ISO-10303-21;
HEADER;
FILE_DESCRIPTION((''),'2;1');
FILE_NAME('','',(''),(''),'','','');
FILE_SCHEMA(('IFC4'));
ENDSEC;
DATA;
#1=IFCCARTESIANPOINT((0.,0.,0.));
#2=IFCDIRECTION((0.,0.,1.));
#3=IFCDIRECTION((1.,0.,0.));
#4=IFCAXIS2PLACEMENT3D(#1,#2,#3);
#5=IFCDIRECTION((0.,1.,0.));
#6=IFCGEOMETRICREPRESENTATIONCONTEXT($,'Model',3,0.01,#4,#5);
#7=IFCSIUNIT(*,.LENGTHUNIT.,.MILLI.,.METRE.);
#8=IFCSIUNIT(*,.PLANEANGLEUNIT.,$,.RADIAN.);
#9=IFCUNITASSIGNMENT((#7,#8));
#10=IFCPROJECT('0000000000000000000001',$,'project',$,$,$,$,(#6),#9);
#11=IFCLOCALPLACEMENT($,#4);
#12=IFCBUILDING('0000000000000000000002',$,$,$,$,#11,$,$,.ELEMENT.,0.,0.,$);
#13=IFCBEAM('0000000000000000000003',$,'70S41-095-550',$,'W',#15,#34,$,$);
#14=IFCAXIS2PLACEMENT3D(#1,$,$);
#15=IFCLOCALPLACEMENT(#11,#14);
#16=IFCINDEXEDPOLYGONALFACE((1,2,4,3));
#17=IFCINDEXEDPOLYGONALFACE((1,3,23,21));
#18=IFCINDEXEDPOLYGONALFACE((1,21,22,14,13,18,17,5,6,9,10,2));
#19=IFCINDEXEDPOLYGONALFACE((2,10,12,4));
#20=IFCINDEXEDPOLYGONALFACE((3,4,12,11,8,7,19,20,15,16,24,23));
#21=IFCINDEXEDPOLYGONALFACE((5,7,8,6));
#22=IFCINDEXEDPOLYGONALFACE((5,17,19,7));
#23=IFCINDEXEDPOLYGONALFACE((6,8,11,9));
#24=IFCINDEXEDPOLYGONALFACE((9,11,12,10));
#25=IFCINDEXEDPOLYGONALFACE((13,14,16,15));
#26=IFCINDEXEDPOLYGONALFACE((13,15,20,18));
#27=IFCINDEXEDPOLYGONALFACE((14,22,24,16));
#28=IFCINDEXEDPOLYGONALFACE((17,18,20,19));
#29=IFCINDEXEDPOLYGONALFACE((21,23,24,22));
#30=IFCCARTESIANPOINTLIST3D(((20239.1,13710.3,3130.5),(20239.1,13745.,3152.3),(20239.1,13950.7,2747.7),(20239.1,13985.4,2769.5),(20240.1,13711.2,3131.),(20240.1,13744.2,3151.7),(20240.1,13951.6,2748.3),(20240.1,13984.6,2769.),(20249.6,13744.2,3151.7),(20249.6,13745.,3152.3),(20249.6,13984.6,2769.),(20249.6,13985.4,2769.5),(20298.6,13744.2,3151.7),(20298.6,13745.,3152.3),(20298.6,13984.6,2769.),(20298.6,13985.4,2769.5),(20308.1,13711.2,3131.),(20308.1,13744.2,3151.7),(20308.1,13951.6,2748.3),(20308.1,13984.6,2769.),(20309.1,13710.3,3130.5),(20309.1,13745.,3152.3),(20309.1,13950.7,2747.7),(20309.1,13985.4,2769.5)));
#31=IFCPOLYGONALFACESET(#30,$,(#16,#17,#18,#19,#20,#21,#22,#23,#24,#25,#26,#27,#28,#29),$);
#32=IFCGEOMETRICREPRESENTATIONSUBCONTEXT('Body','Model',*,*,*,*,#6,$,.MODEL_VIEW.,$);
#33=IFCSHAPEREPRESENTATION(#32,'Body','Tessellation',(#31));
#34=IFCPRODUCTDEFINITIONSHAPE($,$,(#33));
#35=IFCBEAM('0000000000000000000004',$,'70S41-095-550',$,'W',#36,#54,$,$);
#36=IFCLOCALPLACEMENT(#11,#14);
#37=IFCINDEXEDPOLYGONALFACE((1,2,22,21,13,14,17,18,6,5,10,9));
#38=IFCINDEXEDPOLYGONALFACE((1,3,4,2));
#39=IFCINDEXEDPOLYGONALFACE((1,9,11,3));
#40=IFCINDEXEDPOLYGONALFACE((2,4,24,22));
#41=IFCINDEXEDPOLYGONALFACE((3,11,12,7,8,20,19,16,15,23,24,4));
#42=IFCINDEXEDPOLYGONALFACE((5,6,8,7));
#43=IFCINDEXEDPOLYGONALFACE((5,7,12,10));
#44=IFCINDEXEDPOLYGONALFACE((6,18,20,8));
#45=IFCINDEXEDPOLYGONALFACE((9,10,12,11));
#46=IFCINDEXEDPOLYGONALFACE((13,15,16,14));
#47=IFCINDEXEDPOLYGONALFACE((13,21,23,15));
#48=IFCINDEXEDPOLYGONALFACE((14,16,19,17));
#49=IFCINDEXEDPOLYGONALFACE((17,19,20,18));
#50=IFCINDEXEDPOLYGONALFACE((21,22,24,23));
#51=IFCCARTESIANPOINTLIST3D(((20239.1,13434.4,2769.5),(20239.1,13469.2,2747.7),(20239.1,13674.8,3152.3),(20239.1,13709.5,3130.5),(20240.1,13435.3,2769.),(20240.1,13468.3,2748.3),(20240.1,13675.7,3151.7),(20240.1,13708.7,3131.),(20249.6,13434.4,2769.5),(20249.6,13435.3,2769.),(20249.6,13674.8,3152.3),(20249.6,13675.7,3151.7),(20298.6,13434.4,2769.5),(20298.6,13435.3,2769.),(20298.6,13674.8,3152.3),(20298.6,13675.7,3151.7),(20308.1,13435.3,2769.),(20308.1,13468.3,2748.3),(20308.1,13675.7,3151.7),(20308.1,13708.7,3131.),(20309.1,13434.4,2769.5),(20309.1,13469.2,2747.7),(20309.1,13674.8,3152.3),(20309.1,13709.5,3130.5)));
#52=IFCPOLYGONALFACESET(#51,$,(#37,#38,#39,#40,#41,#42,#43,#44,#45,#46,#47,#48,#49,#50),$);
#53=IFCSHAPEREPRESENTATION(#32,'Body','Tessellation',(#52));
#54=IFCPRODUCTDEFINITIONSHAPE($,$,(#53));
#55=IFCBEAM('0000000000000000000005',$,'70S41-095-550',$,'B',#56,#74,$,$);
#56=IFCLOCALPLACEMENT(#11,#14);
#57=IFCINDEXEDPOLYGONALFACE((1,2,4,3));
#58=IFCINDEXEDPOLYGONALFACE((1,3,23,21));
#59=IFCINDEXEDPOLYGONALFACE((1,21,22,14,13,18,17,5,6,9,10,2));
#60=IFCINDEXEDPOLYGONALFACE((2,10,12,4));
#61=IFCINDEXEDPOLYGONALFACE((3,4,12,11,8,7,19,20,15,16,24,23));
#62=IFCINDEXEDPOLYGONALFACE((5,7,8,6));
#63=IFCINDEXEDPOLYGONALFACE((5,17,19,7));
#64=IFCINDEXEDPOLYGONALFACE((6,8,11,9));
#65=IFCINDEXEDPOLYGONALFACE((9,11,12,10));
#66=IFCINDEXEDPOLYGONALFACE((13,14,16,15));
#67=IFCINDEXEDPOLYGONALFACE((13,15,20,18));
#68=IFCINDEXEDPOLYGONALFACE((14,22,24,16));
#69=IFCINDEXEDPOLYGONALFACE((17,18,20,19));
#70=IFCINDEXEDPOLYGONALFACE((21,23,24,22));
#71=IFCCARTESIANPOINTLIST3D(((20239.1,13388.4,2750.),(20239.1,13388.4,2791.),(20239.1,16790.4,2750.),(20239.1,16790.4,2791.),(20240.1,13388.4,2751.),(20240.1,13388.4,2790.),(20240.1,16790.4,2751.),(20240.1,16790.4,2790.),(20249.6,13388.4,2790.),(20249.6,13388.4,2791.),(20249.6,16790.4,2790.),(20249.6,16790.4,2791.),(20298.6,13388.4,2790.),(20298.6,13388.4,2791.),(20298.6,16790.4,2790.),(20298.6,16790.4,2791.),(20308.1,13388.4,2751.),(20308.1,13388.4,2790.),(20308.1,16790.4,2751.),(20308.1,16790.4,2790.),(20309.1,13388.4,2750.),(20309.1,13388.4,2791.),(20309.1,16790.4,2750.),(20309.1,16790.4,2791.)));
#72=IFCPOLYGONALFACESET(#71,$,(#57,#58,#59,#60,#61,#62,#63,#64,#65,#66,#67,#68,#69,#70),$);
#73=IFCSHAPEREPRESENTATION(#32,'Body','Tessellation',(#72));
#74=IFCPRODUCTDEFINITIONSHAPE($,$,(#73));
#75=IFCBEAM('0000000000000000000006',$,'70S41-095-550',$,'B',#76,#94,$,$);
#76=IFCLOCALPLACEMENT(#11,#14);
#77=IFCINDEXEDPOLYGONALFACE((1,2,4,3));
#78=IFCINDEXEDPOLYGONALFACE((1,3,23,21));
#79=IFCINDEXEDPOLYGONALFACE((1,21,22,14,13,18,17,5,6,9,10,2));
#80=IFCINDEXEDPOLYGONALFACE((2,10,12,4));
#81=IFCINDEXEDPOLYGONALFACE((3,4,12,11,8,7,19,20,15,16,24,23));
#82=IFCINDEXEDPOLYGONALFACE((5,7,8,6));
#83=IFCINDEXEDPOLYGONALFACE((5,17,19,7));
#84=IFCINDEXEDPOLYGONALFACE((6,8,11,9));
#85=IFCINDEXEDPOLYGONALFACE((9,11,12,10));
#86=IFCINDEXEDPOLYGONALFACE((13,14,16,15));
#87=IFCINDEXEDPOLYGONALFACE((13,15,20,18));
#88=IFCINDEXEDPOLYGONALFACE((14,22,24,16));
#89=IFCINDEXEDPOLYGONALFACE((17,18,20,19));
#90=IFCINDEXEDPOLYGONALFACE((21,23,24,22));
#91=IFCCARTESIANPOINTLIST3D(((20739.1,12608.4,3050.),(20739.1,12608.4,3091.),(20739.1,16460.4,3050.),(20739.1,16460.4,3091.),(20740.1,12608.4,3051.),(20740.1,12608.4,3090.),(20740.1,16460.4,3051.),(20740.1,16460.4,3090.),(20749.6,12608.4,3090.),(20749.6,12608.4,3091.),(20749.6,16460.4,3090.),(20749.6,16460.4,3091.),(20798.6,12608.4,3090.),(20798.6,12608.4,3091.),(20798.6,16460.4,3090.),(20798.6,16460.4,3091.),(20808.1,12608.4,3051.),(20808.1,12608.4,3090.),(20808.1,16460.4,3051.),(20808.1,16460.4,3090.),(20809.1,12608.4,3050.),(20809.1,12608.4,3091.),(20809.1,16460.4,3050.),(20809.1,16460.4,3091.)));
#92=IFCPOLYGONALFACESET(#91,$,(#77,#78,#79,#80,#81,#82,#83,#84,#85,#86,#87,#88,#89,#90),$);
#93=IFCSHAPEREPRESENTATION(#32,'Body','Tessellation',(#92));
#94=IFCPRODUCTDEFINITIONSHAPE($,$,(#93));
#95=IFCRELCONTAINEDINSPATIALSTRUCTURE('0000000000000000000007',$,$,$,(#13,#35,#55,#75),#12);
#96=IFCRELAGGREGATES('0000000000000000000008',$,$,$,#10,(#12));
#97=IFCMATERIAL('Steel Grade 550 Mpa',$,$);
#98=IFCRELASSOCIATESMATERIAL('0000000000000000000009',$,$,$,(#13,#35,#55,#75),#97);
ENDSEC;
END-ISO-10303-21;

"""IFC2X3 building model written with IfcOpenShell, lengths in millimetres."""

from ifc_helpers import new_model, si_unit, direction, frame, origin, origin_with_axes, origin_2d_with_axis, place, context, subcontext, project, spatial, c_section, extrude, source, transform, mapped, material, element, save


model = new_model("IFC2X3")

# Units and contexts
model_context = context("Model", 3, precision=0.01, world=origin_with_axes(), true_north=direction((0.0, 1.0, 0.0)))
body_context = subcontext(model_context, "Body", "Model", "MODEL_VIEW")
ifc_project = project(units=[si_unit("LENGTHUNIT", "METRE", prefix="MILLI"), si_unit("PLANEANGLEUNIT", "RADIAN")], contexts=[model_context])

# Building
building_placement = place(None, origin_with_axes())
building = spatial("IfcBuilding", under=ifc_project, at=building_placement, CompositionType="ELEMENT", ElevationOfRefHeight=0.0, ElevationOfTerrain=0.0)

# Shared definitions
ifc_material = material(Name="Steel Grade 550 Mpa")

# Beams
shared_shape_1 = source(origin(), body_context, "Body", "SweptSolid", [
    extrude(c_section(Depth=70.0, Width=41.0, WallThickness=1.0, Girth=10.5, at=origin_2d_with_axis()), origin_with_axes(), (0.0, 0.0, 1.0), 451.9),
])
beam_1_placement = place(None, frame((20274.1, 13727.7, 3141.4), z_axis=(0.0, 0.531898, -0.846809), x_axis=(0.0, 0.846809, 0.531898)))
element("IfcBeam", 1, at=beam_1_placement, inside=building, material=ifc_material, Name="70S41-095-550", ObjectType="W", context=body_context, shape_type="MappedRepresentation", body=[
    mapped(shared_shape_1, transform((0.0, 0.0, 0.0), scale=1.0)),
])
shared_shape_2 = source(origin(), body_context, "Body", "SweptSolid", [
    extrude(c_section(Depth=70.0, Width=41.0, WallThickness=1.0, Girth=10.5, at=origin_2d_with_axis()), origin_with_axes(), (0.0, 0.0, 1.0), 451.9),
])
beam_2_placement = place(None, frame((20274.1, 13451.8, 2758.6), z_axis=(0.0, 0.531898, 0.846809), x_axis=(0.0, -0.846809, 0.531898)))
element("IfcBeam", 2, at=beam_2_placement, inside=building, material=ifc_material, Name="70S41-095-550", ObjectType="W", context=body_context, shape_type="MappedRepresentation", body=[
    mapped(shared_shape_2, transform((0.0, 0.0, 0.0), scale=1.0)),
])
shared_shape_3 = source(origin(), body_context, "Body", "SweptSolid", [
    extrude(c_section(Depth=70.0, Width=41.0, WallThickness=1.0, Girth=10.5, at=origin_2d_with_axis()), origin_with_axes(), (0.0, 0.0, 1.0), 3402.0),
])
beam_3_placement = place(None, frame((20274.1, 13388.4, 2770.5), z_axis=(0.0, 1.0, 0.0), x_axis=(0.0, 0.0, 1.0)))
element("IfcBeam", 3, at=beam_3_placement, inside=building, material=ifc_material, Name="70S41-095-550", ObjectType="B", context=body_context, shape_type="MappedRepresentation", body=[
    mapped(shared_shape_3, transform((0.0, 0.0, 0.0), scale=1.0)),
])
shared_shape_4 = source(origin(), body_context, "Body", "SweptSolid", [
    extrude(c_section(Depth=70.0, Width=41.0, WallThickness=1.0, Girth=10.5, at=origin_2d_with_axis()), origin_with_axes(), (0.0, 0.0, 1.0), 3852.0),
])
beam_4_placement = place(None, frame((20774.1, 12608.4, 3070.5), z_axis=(0.0, 1.0, 0.0), x_axis=(0.0, 0.0, 1.0)))
element("IfcBeam", 4, at=beam_4_placement, inside=building, material=ifc_material, Name="70S41-095-550", ObjectType="B", context=body_context, shape_type="MappedRepresentation", body=[
    mapped(shared_shape_4, transform((0.0, 0.0, 0.0), scale=1.0)),
])

save(model, "model.ifc")
